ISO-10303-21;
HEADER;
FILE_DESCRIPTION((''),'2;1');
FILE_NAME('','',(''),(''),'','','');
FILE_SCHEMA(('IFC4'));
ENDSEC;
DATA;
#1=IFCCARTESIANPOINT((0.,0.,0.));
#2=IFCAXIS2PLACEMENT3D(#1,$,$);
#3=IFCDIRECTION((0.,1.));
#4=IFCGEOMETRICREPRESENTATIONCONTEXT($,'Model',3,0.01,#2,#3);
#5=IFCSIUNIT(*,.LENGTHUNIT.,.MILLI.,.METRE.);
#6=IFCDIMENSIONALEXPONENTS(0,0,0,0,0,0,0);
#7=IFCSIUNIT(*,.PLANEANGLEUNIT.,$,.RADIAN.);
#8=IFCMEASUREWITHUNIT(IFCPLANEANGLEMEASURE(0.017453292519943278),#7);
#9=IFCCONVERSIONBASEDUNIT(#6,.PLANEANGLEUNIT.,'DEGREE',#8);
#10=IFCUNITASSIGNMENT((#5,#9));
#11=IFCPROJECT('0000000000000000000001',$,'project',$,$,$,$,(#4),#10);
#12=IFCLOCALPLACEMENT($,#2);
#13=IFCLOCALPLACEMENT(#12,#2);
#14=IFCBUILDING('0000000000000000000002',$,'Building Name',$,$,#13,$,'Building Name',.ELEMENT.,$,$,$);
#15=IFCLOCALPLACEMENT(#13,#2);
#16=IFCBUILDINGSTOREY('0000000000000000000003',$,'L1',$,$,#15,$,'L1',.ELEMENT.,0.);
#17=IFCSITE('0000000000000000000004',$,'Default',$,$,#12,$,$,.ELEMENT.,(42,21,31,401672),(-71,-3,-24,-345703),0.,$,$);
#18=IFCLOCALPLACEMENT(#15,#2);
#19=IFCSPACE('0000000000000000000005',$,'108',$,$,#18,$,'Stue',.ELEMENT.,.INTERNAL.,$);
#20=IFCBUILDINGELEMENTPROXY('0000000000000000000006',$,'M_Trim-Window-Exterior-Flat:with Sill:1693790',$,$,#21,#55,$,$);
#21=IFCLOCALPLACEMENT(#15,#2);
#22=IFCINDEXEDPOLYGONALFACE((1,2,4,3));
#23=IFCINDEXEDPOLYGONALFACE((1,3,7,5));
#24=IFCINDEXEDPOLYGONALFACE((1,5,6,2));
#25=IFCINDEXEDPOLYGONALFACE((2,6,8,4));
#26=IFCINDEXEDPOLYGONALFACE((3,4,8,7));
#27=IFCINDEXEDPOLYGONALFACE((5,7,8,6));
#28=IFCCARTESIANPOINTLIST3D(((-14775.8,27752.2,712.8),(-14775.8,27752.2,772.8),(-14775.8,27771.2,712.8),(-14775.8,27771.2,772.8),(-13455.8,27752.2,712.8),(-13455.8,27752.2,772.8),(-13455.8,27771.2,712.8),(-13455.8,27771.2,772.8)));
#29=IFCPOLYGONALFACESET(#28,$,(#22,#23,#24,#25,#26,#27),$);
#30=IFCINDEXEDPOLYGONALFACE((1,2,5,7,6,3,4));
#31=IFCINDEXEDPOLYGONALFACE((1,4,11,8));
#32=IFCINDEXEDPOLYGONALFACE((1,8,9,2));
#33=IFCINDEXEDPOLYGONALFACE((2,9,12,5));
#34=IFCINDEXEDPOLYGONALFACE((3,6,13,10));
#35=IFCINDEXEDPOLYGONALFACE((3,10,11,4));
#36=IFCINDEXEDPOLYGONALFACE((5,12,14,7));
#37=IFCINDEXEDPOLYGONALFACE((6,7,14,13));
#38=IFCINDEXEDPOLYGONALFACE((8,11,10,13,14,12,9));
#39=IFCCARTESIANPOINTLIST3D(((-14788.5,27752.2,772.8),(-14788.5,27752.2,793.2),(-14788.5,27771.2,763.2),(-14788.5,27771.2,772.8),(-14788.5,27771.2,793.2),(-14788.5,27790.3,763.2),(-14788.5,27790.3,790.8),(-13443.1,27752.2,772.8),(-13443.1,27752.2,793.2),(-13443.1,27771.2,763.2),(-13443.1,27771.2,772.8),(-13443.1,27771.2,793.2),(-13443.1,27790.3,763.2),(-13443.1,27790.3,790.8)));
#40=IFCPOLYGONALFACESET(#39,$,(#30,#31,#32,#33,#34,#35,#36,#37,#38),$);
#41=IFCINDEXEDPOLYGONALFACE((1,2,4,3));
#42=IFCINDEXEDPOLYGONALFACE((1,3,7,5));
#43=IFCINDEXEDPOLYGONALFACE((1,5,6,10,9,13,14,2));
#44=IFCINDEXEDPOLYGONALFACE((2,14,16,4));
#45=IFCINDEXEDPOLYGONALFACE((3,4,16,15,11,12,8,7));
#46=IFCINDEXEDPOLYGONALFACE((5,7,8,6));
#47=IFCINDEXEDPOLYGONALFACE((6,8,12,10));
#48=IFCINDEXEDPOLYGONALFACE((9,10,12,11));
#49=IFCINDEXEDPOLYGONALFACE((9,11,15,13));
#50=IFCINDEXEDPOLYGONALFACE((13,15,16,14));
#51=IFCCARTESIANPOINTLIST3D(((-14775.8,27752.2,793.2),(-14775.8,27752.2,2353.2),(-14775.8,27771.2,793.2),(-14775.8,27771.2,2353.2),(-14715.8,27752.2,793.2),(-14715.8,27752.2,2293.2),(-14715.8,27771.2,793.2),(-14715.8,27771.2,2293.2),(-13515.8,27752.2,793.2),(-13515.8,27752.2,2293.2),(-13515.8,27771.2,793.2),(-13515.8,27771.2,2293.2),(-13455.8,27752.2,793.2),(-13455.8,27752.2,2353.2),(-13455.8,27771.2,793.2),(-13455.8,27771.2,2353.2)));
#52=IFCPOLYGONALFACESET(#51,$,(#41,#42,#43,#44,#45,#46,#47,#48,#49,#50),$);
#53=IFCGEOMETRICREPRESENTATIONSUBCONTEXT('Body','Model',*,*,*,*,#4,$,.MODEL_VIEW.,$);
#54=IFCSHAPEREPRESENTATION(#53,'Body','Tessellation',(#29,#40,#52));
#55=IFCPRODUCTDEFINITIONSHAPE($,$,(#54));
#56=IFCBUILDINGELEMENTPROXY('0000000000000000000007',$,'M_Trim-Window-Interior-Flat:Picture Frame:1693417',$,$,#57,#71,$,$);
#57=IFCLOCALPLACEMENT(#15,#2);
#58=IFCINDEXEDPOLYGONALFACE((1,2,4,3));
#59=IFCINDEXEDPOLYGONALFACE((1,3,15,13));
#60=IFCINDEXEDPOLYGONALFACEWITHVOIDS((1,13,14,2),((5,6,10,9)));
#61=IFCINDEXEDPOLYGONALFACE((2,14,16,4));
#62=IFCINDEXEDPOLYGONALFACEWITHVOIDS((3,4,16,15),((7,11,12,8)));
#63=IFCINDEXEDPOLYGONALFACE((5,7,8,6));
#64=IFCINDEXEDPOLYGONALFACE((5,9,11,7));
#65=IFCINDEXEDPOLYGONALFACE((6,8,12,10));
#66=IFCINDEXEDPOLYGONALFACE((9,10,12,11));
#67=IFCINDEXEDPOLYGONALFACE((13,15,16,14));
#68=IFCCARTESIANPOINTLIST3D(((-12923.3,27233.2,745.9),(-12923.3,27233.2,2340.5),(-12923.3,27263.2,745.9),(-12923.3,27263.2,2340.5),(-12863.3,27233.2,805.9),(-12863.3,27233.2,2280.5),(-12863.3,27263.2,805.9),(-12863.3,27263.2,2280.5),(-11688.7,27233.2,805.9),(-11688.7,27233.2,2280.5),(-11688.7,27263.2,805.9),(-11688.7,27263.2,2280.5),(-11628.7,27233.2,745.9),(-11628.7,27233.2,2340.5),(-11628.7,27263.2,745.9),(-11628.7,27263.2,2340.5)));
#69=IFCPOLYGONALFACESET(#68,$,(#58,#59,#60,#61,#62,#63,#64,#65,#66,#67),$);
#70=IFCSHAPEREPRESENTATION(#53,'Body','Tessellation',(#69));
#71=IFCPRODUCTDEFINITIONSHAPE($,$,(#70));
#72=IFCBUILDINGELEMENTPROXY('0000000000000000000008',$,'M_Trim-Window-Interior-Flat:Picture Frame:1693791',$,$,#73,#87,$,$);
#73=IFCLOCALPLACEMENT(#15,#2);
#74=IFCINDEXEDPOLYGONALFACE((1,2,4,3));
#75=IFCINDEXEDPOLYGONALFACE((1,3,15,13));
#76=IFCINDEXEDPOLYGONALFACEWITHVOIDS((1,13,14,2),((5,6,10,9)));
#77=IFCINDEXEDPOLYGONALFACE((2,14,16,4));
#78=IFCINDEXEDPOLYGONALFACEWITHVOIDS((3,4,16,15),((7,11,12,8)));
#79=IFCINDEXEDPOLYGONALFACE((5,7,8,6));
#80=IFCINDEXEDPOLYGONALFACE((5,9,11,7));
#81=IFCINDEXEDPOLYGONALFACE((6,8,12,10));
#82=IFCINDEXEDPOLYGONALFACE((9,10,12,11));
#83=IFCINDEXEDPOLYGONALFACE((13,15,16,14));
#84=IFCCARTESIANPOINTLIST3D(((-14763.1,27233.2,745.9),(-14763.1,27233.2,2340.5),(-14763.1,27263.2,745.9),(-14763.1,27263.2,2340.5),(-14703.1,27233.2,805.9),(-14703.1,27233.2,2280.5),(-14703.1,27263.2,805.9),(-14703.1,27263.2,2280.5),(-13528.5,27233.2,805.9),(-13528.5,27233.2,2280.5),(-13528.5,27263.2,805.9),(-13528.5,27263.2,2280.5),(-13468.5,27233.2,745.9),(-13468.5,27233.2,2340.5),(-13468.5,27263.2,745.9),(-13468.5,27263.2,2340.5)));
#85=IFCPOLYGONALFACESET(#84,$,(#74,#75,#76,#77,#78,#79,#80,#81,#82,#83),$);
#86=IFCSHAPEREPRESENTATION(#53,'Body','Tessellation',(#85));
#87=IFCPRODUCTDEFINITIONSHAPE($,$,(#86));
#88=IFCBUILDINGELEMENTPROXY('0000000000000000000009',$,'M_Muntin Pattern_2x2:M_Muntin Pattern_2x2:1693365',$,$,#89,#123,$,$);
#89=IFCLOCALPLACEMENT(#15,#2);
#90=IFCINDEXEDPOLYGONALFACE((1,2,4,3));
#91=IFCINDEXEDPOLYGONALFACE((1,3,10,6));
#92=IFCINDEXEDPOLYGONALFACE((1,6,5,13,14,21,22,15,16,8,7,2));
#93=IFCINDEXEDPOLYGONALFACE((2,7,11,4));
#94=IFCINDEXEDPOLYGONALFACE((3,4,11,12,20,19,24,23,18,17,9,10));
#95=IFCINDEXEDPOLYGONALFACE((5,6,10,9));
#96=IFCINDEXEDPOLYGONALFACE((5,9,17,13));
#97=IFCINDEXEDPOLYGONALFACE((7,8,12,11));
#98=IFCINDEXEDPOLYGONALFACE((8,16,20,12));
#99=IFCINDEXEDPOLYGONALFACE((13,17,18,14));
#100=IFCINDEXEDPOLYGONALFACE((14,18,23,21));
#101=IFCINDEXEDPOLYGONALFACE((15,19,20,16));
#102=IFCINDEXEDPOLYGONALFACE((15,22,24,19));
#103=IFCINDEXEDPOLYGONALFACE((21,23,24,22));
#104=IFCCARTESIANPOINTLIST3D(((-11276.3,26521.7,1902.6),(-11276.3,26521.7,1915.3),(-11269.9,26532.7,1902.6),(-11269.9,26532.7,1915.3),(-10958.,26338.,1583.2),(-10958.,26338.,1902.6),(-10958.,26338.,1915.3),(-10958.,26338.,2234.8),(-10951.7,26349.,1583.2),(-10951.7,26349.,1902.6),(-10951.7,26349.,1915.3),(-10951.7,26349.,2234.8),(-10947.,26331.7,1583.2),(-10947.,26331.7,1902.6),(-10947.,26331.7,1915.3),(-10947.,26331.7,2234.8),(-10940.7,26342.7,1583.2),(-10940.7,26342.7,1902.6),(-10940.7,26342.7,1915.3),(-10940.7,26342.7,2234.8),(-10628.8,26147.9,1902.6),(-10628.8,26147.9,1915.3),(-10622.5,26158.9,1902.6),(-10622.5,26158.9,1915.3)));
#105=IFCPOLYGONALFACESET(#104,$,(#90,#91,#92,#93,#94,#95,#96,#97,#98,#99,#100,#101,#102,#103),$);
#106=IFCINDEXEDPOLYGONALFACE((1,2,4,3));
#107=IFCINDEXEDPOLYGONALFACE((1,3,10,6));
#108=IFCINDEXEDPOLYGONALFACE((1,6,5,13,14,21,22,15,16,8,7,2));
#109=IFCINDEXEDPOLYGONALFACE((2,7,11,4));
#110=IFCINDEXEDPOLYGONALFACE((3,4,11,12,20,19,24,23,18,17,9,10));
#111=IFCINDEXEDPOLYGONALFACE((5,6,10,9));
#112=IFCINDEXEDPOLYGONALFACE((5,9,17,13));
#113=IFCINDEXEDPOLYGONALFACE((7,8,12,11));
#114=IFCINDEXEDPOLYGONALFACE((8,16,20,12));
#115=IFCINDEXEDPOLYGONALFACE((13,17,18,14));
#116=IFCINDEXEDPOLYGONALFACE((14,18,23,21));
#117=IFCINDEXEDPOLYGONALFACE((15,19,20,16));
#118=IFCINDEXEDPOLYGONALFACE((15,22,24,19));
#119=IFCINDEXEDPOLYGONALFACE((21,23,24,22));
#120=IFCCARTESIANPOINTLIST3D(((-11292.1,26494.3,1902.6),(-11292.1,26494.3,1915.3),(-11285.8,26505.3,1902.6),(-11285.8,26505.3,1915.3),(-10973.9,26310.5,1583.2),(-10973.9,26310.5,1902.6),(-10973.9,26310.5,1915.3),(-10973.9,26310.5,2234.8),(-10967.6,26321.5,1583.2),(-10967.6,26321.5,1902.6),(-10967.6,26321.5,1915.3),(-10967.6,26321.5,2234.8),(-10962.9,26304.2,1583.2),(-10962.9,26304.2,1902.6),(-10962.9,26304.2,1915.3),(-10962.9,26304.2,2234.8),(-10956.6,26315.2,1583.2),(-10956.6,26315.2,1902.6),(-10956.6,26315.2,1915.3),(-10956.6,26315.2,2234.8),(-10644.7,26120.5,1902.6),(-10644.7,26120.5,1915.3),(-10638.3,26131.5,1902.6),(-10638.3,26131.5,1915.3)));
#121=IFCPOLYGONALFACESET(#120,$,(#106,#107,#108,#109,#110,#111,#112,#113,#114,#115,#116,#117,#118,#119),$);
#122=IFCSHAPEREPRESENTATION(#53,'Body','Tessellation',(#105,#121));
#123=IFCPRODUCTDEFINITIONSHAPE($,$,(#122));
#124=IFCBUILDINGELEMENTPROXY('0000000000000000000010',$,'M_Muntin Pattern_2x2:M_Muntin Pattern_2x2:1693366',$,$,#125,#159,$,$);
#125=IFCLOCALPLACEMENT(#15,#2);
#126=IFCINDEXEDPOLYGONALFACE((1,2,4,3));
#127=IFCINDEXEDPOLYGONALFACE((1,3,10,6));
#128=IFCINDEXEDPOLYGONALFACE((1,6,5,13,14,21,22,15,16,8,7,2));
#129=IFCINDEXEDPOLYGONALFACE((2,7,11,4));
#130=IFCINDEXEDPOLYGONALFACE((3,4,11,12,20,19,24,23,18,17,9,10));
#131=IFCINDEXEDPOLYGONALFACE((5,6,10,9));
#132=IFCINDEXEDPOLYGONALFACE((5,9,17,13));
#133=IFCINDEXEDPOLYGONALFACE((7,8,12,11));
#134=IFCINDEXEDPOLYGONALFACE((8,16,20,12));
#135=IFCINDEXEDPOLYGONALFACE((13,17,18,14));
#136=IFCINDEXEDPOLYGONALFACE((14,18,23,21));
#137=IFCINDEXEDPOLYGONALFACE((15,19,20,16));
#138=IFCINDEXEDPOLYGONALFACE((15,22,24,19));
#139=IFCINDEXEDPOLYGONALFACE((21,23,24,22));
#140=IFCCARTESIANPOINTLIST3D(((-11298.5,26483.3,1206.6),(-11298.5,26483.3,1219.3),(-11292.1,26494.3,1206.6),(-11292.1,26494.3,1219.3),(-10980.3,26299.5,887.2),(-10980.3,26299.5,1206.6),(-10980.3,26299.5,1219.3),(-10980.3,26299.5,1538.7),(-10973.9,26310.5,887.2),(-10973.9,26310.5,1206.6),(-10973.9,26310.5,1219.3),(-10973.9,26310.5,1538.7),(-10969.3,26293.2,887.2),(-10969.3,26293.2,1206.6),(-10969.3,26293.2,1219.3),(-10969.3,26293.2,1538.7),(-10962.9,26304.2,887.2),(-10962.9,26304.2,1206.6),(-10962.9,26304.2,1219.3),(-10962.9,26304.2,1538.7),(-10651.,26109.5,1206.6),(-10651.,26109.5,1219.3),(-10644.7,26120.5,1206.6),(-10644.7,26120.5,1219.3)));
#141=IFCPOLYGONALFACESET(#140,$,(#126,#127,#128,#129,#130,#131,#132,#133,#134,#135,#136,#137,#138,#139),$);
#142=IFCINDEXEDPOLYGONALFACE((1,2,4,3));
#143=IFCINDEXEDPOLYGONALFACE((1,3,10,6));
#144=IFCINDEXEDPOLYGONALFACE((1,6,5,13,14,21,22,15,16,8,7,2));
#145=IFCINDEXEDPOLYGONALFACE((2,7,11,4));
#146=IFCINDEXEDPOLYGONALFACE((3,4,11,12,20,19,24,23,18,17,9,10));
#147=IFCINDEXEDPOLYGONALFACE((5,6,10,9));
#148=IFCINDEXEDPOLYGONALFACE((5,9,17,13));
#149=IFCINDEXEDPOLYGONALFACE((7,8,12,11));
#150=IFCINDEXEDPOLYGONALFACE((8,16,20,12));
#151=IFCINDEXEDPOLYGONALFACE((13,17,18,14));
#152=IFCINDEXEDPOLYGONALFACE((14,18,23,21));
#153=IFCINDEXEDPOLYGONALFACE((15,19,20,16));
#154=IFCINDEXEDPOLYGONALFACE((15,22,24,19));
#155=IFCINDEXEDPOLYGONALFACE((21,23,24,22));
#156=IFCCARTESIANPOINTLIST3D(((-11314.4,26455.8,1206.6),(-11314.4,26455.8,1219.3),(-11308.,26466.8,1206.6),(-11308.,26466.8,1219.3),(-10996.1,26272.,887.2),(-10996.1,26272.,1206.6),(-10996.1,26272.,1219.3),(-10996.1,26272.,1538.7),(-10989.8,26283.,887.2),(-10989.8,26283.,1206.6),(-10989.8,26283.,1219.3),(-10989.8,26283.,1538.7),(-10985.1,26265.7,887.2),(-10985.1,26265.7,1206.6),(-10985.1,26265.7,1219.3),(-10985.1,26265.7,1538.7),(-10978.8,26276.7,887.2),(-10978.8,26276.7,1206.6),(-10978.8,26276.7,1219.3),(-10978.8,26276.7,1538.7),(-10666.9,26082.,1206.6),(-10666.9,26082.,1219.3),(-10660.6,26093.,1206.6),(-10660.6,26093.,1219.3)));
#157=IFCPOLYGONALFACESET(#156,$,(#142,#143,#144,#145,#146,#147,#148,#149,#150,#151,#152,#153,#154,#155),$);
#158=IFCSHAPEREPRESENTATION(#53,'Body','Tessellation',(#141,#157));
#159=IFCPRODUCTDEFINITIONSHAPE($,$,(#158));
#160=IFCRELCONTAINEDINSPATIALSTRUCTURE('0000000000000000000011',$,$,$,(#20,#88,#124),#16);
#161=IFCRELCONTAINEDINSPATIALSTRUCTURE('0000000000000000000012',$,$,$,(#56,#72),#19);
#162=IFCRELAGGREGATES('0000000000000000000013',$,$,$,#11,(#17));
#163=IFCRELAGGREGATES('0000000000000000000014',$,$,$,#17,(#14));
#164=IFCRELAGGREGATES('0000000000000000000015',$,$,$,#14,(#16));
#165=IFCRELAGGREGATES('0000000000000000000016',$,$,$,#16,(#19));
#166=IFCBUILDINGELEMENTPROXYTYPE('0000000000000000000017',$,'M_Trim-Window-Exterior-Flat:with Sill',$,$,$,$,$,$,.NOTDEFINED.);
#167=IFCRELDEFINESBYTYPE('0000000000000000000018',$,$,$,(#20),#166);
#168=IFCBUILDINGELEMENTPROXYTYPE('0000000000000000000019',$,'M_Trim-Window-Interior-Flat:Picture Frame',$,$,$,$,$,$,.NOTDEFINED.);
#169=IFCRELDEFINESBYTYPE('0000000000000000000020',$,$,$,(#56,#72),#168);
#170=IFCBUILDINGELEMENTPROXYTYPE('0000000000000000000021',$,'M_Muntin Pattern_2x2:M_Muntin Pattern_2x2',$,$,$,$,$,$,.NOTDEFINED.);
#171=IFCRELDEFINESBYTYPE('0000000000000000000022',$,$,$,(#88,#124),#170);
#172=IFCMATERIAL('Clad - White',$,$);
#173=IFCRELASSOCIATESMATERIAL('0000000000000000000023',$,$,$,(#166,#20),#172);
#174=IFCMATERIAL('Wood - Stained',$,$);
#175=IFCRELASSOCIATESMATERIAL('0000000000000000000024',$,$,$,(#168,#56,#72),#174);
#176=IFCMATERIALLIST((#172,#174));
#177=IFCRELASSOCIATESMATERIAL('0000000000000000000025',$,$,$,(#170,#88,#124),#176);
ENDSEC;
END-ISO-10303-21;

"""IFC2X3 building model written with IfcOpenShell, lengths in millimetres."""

from ifc_helpers import new_model, entity, si_unit, converted_unit, direction, frame, frame_2d, origin, place, context, subcontext, project, spatial, polyline, rectangle, outline, extrude, source, transform, mapped, material, material_list, type_object, type_shapes, element, save


model = new_model("IFC2X3")

# Units and contexts
model_context = context("Model", 3, precision=0.01, world=origin(), true_north=direction((0.0, 1.0)))
body_context = subcontext(model_context, "Body", "Model", "MODEL_VIEW")
ifc_project = project(units=[si_unit("LENGTHUNIT", "METRE", prefix="MILLI"), converted_unit("PLANEANGLEUNIT", "DEGREE", entity("IfcPlaneAngleMeasure", 0.017453292519943278), si_unit("PLANEANGLEUNIT", "RADIAN"), dimensions=[0, 0, 0, 0, 0, 0, 0])], contexts=[model_context])

# Site, building, storey
site_placement = place(None, origin())
site = spatial("IfcSite", under=ifc_project, at=site_placement, Name="Default", CompositionType="ELEMENT", RefLatitude=(42, 21, 31, 401672), RefLongitude=(-71, -3, -24, -345703), RefElevation=0.0)
building_placement = place(site_placement, origin())
building = spatial("IfcBuilding", under=site, at=building_placement, Name="Building Name", LongName="Building Name", CompositionType="ELEMENT")
storey_placement = place(building_placement, origin())
storey = spatial("IfcBuildingStorey", under=building, at=storey_placement, Name="L1", LongName="L1", CompositionType="ELEMENT", Elevation=0.0)

# Shared definitions
ifc_material_1 = material(Name="Wood - Stained")

# Building element proxy
ifc_material_2 = material(Name="Clad - White")
ifc_material_list_1 = material_list([ifc_material_2, ifc_material_1])
building_element_proxy_type_1 = type_object("IfcBuildingElementProxyType", Name="M_Trim-Window-Exterior-Flat:with Sill", PredefinedType="NOTDEFINED", material=ifc_material_2)
shared_shape_1 = source(origin(), body_context, "Body", "SweptSolid", [
    extrude(rectangle(XDim=1320.0, YDim=60.0, at=frame_2d((0.0, 0.0), x_axis=(1.0, 0.0))), frame((0.0, -1550.4, 0.0), z_axis=(0.0, 0.0, 1.0), x_axis=(-1.0, 0.0, 0.0)), (0.0, 0.0, 1.0), 19.0),
    extrude(outline(polyline([(-19.0, -15.2), (0.0, -15.2), (0.0, -5.7), (19.0, -5.7), (19.0, 14.8), (0.0, 14.8), (-19.0, 12.3), (-19.0, -15.2)])), frame((-672.7, -1514.8, 19.0), z_axis=(1.0, 0.0, 0.0), x_axis=(0.0, 0.0, -1.0)), (0.0, 0.0, 1.0), 1345.4),
    extrude(outline(polyline([(-795.0, -660.0), (765.0, -660.0), (765.0, -600.0), (-735.0, -600.0), (-735.0, 600.0), (765.0, 600.0), (765.0, 660.0), (-795.0, 660.0), (-795.0, -660.0)])), frame((0.0, -735.0, 0.0), z_axis=(0.0, 0.0, 1.0), x_axis=(0.0, -1.0, 0.0)), (0.0, 0.0, 1.0), 19.0),
])
type_shapes(building_element_proxy_type_1, [shared_shape_1])
for number, where, z_axis, x_axis, name in (
    (1, (-14115.8, 27752.2, 2293.2), (0.0, 1.0, 0.0), (-1.0, 0.0, 0.0), "M_Trim-Window-Exterior-Flat:with Sill:1693790"),
):
    element("IfcBuildingElementProxy", number, at=place(storey_placement, frame(where, z_axis=z_axis, x_axis=x_axis)), inside=storey, type_object=building_element_proxy_type_1, material=ifc_material_2, Name=name, context=body_context, shape_type="MappedRepresentation", body=[
        mapped(shared_shape_1, transform((0.0, 0.0, 0.0), scale=1.0)),
    ])

# Shared definitions
space_placement = place(storey_placement, origin())
space = spatial("IfcSpace", under=storey, at=space_placement, Name="108", LongName="Stue", CompositionType="ELEMENT", InteriorOrExteriorSpace="INTERNAL")

# Building element proxies
building_element_proxy_type_2 = type_object("IfcBuildingElementProxyType", Name="M_Trim-Window-Interior-Flat:Picture Frame", PredefinedType="NOTDEFINED", material=ifc_material_1)
shared_shape_2 = source(origin(), body_context, "Body", "SweptSolid", [
    extrude(outline(polyline([(-647.3, -797.3), (647.3, -797.3), (647.3, 797.3), (-647.3, 797.3), (-647.3, -797.3)]), holes=[polyline([(-587.3, -737.3), (-587.3, 737.3), (587.3, 737.3), (587.3, -737.3), (-587.3, -737.3)])]), frame((0.0, -750.0, 0.0), z_axis=(0.0, 0.0, 1.0), x_axis=(-1.0, 0.0, 0.0)), (0.0, 0.0, 1.0), 30.0),
])
type_shapes(building_element_proxy_type_2, [shared_shape_2])
for number, where, z_axis, x_axis, name in (
    (2, (-12276.0, 27263.2, 2293.2), (0.0, -1.0, 0.0), (1.0, 0.0, 0.0), "M_Trim-Window-Interior-Flat:Picture Frame:1693417"),
    (3, (-14115.8, 27263.2, 2293.2), (0.0, -1.0, 0.0), (1.0, 0.0, 0.0), "M_Trim-Window-Interior-Flat:Picture Frame:1693791"),
):
    element("IfcBuildingElementProxy", number, at=place(space_placement, frame(where, z_axis=z_axis, x_axis=x_axis)), inside=space, type_object=building_element_proxy_type_2, material=ifc_material_1, Name=name, context=body_context, shape_type="MappedRepresentation", body=[
        mapped(shared_shape_2, transform((0.0, 0.0, 0.0), scale=1.0)),
    ])
building_element_proxy_type_3 = type_object("IfcBuildingElementProxyType", Name="M_Muntin Pattern_2x2:M_Muntin Pattern_2x2", PredefinedType="NOTDEFINED", material=ifc_material_list_1)
shared_shape_3 = source(origin(), body_context, "Body", "SweptSolid", [
    extrude(outline(polyline([(6.4, -6.4), (325.8, -6.4), (325.8, 6.3), (6.4, 6.3), (6.4, 373.8), (-6.3, 373.8), (-6.3, 6.3), (-325.8, 6.3), (-325.8, -6.4), (-6.3, -6.4), (-6.3, -373.8), (6.4, -373.8), (6.4, -6.4)])), frame((0.0, 9.5, 325.8), z_axis=(0.0, 1.0, 0.0), x_axis=(0.0, 0.0, 1.0)), (0.0, 0.0, 1.0), 12.7),
    extrude(outline(polyline([(6.4, -6.4), (325.8, -6.4), (325.8, 6.3), (6.4, 6.3), (6.4, 373.8), (-6.3, 373.8), (-6.3, 6.3), (-325.8, 6.3), (-325.8, -6.4), (-6.3, -6.4), (-6.3, -373.8), (6.4, -373.8), (6.4, -6.4)])), frame((0.0, -22.2, 325.8), z_axis=(0.0, 1.0, 0.0), x_axis=(0.0, 0.0, 1.0)), (0.0, 0.0, 1.0), 12.7),
])
type_shapes(building_element_proxy_type_3, [shared_shape_3])
for number, where, z_axis, x_axis, name in (
    (4, (-10957.3, 26326.6, 1583.2), (0.0, 0.0, 1.0), (0.866025, -0.5, 0.0), "M_Muntin Pattern_2x2:M_Muntin Pattern_2x2:1693365"),
    (5, (-10979.5, 26288.1, 887.2), (0.0, 0.0, 1.0), (0.866025, -0.5, 0.0), "M_Muntin Pattern_2x2:M_Muntin Pattern_2x2:1693366"),
):
    element("IfcBuildingElementProxy", number, at=place(storey_placement, frame(where, z_axis=z_axis, x_axis=x_axis)), inside=storey, type_object=building_element_proxy_type_3, material=ifc_material_list_1, Name=name, context=body_context, shape_type="MappedRepresentation", body=[
        mapped(shared_shape_3, transform((0.0, 0.0, 0.0), scale=1.0)),
    ])

save(model, "model.ifc")
